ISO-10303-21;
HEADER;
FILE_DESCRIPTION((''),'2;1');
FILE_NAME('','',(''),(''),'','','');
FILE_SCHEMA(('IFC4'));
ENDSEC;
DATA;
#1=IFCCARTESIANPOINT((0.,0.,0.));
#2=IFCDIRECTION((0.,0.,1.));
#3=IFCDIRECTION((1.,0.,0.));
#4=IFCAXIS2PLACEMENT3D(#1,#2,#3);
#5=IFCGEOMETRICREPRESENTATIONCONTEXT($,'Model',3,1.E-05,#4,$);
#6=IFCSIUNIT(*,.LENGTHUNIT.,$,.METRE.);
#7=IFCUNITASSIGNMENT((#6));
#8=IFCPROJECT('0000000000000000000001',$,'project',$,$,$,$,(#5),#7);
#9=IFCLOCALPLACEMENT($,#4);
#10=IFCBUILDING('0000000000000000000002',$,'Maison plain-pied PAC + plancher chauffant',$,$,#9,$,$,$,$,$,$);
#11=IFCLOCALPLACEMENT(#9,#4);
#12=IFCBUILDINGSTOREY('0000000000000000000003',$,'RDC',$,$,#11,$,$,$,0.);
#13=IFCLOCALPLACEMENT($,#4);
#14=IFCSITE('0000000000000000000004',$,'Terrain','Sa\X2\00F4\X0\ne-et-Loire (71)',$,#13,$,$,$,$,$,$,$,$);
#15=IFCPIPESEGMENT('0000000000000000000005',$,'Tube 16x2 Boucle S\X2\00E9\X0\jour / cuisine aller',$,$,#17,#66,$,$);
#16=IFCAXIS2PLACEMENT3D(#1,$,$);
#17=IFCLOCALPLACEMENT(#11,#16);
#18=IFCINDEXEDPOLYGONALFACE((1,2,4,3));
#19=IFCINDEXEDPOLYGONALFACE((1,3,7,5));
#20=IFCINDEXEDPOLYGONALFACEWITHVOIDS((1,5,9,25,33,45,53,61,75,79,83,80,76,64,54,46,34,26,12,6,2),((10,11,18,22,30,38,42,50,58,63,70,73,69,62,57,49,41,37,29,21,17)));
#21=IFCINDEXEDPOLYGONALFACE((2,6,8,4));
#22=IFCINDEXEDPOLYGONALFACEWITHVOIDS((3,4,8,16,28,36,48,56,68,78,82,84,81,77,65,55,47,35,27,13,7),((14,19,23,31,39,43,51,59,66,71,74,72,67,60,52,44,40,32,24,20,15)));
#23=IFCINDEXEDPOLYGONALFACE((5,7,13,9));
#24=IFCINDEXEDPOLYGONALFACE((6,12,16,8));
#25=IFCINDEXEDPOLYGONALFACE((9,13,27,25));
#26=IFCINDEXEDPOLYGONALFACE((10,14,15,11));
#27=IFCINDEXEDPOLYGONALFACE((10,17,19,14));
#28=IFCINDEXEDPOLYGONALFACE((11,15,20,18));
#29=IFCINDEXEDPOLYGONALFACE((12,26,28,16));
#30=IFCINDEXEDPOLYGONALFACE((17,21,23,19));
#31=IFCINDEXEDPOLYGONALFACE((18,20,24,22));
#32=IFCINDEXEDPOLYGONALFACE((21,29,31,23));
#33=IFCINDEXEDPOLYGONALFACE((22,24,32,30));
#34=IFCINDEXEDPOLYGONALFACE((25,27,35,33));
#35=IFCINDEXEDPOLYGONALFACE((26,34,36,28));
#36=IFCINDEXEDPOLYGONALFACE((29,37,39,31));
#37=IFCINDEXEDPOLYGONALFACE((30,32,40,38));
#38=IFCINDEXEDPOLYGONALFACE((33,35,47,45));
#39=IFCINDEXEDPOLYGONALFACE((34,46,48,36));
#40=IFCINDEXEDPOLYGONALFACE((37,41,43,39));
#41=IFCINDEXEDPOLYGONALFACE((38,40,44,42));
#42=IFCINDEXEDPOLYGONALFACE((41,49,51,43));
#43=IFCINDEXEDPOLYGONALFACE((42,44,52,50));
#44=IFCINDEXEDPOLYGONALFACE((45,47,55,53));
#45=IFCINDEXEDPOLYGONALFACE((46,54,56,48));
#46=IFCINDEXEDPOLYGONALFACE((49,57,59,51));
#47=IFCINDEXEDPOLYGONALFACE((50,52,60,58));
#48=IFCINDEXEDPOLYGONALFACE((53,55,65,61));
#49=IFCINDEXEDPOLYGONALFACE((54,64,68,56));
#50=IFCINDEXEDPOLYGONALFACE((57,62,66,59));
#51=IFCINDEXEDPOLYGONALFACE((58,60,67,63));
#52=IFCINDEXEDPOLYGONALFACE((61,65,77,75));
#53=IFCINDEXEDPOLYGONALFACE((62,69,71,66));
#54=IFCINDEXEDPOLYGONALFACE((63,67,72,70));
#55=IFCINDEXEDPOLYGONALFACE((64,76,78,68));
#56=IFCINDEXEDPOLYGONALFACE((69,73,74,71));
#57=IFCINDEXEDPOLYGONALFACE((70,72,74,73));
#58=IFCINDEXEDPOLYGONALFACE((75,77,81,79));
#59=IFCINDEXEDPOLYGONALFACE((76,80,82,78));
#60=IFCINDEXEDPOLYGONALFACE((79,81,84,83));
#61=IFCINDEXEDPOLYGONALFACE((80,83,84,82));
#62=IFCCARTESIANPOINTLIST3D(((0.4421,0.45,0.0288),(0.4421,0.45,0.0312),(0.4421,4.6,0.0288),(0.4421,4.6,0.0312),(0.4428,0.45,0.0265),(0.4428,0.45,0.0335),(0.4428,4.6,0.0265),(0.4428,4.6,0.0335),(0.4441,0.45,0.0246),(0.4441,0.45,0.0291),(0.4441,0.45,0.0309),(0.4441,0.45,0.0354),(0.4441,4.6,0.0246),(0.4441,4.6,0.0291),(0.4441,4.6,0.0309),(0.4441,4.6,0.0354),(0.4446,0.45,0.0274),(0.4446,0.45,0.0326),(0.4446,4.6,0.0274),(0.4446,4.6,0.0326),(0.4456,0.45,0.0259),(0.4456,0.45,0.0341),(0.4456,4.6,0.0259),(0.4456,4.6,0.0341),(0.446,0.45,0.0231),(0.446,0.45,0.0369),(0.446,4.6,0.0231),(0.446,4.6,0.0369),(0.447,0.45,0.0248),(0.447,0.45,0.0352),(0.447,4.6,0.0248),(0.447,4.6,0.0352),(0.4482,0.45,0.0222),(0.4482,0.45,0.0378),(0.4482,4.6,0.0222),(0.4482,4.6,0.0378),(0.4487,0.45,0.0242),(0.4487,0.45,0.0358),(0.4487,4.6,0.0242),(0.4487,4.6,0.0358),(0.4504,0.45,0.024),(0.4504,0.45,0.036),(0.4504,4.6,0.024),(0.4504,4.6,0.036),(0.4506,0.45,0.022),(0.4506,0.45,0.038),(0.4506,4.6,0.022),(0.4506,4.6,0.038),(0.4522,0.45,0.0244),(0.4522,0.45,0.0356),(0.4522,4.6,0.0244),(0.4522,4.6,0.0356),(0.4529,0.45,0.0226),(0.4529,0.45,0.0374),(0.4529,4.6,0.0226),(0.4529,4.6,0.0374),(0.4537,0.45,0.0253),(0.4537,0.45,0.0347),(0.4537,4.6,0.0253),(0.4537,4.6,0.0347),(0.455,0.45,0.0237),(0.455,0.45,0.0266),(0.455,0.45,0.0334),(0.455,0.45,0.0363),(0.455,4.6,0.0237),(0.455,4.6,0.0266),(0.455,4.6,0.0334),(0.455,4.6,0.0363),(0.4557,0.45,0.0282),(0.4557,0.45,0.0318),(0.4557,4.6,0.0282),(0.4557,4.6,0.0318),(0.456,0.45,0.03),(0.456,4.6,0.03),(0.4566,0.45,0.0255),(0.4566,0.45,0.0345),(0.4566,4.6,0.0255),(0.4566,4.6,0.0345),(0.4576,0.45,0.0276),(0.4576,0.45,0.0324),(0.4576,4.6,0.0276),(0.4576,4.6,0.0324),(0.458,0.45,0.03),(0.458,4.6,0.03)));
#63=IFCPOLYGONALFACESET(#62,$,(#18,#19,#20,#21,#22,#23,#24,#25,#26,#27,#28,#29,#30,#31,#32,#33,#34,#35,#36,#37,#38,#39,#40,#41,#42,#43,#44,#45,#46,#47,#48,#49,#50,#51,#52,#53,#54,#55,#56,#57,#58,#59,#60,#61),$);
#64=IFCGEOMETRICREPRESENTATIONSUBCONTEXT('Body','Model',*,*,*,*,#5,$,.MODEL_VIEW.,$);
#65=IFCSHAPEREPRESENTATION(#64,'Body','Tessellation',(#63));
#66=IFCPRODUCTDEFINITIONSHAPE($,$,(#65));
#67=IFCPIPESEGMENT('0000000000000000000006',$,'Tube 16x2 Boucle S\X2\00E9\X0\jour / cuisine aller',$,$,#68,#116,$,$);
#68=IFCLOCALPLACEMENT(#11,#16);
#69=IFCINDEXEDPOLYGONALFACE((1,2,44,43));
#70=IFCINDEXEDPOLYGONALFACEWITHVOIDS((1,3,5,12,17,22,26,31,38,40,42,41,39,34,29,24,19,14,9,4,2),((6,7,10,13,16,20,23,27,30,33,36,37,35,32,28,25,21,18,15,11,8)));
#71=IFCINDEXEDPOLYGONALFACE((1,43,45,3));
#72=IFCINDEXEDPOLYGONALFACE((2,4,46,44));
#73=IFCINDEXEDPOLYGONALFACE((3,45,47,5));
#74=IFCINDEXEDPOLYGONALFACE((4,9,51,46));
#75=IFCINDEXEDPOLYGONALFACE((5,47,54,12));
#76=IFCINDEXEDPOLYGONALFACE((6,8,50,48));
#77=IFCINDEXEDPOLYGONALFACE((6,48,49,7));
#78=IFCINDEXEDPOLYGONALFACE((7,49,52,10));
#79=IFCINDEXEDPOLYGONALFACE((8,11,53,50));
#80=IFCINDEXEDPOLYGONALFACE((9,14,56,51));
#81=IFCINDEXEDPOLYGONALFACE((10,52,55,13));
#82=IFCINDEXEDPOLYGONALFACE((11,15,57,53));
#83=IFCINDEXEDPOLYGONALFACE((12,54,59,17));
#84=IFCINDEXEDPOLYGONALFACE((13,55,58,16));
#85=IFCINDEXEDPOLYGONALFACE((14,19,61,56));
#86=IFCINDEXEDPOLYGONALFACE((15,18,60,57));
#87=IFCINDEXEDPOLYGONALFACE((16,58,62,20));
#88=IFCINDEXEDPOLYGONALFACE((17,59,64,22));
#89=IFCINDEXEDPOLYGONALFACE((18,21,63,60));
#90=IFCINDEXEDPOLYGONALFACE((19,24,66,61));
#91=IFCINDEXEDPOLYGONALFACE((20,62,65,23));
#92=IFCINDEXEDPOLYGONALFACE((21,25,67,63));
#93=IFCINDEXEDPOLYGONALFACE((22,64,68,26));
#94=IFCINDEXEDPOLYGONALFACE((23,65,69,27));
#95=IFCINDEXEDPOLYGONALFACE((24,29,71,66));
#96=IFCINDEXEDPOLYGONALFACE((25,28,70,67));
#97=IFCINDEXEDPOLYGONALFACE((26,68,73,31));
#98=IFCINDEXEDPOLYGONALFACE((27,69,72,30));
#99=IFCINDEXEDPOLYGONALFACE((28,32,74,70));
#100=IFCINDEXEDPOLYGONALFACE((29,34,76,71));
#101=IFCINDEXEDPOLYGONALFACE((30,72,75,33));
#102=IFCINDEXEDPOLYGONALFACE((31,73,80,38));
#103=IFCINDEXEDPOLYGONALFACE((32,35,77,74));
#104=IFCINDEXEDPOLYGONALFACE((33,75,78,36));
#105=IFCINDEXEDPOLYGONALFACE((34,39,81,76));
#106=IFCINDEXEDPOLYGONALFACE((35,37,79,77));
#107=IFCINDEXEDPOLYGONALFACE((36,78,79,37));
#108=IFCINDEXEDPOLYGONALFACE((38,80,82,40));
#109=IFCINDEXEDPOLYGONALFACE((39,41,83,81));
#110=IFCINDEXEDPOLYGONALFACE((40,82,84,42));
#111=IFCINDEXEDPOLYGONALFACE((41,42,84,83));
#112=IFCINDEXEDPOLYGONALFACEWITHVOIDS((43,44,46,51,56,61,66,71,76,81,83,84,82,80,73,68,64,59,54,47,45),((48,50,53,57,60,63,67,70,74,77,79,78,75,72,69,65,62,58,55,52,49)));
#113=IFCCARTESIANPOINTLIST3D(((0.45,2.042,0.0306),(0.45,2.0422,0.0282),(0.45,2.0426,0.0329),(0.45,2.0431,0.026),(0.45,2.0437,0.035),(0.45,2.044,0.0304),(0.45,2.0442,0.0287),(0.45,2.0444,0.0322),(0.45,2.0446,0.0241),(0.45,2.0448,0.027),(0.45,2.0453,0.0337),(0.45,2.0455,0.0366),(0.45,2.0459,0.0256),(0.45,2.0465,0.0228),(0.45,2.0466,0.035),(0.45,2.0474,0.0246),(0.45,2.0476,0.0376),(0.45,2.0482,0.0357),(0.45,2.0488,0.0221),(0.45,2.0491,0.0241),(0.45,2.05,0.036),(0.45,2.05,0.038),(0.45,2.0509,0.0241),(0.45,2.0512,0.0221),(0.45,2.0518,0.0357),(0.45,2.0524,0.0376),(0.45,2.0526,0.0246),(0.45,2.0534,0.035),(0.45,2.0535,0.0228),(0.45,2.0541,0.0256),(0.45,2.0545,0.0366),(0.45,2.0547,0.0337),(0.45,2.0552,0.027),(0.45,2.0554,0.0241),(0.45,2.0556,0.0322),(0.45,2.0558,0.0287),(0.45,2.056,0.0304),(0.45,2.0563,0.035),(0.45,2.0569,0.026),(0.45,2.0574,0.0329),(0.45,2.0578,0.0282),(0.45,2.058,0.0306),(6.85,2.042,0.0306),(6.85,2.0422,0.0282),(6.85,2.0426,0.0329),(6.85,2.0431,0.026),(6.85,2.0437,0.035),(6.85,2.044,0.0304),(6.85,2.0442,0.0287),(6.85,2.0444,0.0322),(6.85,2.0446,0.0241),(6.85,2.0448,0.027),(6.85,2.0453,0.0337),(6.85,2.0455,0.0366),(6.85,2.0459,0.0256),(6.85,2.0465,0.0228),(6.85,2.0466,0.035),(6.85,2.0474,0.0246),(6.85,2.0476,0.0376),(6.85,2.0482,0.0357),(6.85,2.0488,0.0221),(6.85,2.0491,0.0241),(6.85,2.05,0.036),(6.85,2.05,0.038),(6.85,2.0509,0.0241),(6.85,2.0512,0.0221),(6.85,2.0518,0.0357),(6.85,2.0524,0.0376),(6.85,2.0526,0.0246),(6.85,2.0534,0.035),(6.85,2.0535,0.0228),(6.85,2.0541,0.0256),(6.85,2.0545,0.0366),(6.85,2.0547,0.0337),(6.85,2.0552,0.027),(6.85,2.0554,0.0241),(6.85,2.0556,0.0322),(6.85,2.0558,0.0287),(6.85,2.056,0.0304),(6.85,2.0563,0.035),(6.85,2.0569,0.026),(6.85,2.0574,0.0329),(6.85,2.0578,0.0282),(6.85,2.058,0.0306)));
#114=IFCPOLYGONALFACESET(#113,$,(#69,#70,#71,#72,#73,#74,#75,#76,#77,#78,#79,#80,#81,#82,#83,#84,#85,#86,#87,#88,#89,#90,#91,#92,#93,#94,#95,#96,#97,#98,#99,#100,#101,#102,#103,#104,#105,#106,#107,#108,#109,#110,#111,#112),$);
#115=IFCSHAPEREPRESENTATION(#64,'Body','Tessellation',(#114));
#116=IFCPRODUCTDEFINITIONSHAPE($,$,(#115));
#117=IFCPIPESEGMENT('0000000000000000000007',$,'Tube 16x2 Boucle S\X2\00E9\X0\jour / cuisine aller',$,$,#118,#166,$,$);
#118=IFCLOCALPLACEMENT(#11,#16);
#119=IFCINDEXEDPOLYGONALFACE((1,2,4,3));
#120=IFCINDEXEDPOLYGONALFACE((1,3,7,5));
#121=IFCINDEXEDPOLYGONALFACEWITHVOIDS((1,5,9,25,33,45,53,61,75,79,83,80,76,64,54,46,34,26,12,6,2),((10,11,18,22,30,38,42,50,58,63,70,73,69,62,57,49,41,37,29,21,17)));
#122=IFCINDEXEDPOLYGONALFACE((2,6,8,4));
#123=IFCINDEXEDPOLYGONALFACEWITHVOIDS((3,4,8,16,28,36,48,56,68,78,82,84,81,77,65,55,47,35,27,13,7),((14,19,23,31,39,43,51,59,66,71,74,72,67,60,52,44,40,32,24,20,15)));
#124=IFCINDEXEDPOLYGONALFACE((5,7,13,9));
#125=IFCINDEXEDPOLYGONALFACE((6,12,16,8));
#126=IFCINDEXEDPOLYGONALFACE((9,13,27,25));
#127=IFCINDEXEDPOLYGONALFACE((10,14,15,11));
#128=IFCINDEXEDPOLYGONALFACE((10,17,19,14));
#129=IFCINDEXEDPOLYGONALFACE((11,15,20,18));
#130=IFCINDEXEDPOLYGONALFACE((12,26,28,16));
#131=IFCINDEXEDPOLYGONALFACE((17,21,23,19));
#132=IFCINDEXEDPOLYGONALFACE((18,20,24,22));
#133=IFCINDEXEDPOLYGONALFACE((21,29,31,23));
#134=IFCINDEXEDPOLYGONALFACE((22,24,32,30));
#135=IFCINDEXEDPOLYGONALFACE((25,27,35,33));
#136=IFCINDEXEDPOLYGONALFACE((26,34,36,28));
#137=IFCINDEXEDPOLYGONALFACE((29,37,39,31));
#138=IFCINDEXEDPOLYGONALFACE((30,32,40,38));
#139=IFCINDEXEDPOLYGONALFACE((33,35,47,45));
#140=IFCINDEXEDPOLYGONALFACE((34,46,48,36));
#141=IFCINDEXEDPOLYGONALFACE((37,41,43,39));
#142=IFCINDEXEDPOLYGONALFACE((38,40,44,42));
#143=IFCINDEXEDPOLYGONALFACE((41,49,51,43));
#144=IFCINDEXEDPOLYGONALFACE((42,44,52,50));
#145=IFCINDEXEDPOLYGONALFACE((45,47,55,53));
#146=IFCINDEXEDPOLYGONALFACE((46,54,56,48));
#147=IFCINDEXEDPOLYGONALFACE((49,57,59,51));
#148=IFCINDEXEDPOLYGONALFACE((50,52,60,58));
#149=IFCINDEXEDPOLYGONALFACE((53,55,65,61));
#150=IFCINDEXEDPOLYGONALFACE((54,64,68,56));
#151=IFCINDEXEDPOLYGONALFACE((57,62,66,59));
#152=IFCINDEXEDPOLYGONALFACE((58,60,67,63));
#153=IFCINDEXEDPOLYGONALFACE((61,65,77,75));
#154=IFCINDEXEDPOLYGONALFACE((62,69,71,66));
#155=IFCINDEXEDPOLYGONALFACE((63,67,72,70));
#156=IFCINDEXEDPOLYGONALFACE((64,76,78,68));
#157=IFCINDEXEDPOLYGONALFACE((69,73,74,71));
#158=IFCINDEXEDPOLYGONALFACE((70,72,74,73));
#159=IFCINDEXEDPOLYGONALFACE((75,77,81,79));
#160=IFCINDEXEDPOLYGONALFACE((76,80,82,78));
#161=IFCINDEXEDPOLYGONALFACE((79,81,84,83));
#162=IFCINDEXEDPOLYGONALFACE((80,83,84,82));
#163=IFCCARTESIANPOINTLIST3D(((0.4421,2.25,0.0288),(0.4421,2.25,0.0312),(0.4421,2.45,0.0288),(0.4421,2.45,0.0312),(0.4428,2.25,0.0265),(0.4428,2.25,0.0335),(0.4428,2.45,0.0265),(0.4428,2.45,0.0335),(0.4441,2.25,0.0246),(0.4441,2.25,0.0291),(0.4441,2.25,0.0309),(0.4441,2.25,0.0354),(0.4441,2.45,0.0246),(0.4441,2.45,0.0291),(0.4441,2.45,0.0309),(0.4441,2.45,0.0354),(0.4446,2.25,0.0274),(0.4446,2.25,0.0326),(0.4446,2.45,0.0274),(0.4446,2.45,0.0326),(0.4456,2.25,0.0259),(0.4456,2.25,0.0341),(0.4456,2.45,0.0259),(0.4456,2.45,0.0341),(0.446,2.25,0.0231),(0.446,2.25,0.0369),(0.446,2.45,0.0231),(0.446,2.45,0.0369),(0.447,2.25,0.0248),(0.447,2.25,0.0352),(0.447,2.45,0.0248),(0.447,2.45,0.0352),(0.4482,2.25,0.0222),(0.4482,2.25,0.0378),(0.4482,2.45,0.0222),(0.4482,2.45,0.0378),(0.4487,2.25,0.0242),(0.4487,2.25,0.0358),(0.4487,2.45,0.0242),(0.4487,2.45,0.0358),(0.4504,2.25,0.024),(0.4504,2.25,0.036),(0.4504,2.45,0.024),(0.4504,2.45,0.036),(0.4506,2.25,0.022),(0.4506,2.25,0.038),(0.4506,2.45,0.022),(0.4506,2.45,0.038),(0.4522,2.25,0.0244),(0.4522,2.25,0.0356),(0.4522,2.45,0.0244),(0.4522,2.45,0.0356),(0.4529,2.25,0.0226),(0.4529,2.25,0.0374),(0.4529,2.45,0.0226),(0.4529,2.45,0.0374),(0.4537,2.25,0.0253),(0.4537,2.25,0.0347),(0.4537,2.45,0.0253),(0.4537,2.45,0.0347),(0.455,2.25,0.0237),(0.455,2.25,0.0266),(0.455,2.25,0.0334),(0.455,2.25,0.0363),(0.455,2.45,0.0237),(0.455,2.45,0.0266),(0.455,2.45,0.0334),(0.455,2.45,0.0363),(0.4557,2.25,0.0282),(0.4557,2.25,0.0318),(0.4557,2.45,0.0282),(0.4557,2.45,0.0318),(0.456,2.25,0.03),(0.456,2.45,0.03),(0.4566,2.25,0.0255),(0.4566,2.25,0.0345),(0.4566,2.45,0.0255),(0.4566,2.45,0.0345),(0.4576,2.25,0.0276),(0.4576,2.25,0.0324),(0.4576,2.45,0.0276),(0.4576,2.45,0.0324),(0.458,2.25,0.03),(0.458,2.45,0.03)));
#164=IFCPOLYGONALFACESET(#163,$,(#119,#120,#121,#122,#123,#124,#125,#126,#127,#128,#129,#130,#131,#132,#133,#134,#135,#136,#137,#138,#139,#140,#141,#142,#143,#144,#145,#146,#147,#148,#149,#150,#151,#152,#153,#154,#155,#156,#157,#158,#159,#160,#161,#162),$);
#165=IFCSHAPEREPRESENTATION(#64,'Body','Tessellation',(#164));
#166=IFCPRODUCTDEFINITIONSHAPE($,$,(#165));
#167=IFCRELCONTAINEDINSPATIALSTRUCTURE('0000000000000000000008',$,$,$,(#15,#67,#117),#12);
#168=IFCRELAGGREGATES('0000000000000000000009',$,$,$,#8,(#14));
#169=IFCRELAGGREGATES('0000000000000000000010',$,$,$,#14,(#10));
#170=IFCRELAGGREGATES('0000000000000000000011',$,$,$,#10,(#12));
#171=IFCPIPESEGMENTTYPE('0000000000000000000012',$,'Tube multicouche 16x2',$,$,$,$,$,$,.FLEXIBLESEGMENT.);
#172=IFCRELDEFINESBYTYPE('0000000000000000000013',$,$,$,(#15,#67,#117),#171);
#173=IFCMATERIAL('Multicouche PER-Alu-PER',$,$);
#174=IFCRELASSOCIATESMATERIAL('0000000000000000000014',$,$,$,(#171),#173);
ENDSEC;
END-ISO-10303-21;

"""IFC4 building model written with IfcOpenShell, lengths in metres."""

from ifc_helpers import new_model, si_unit, frame, origin_with_axes, place, context, subcontext, project, spatial, hollow_circle, extrude, material, type_object, element, save


model = new_model("IFC4")

# Units and contexts
model_context = context("Model", 3, precision=1e-05, world=origin_with_axes())
body_context = subcontext(model_context, "Body", "Model", "MODEL_VIEW")
ifc_project = project(units=[si_unit("LENGTHUNIT", "METRE")], contexts=[model_context])

# Site, building, storey
site_placement = place(None, origin_with_axes())
site = spatial("IfcSite", under=ifc_project, at=site_placement, Name="Terrain", Description="Saône-et-Loire (71)")
building_placement = place(None, origin_with_axes())
building = spatial("IfcBuilding", under=site, at=building_placement, Name="Maison plain-pied PAC + plancher chauffant")
storey_placement = place(building_placement, origin_with_axes())
storey = spatial("IfcBuildingStorey", under=building, at=storey_placement, Name="RDC", Elevation=0.0)

# Pipe segments
ifc_material = material(Name="Multicouche PER-Alu-PER")
pipe_segment_type = type_object("IfcPipeSegmentType", Name="Tube multicouche 16x2", PredefinedType="FLEXIBLESEGMENT", material=ifc_material)
pipe_segment_1_placement = place(storey_placement, frame((0.45, 4.6, 0.03), z_axis=(0.0, -1.0, 0.0), x_axis=(1.0, 0.0, 0.0)))
element("IfcPipeSegment", 1, at=pipe_segment_1_placement, inside=storey, type_object=pipe_segment_type, Name="Tube 16x2 Boucle Séjour / cuisine aller", context=body_context, shape_type="SweptSolid", body=[
    extrude(hollow_circle(Radius=0.008, WallThickness=0.002), origin_with_axes(), (0.0, 0.0, 1.0), 4.15),
])
pipe_segment_2_placement = place(storey_placement, frame((0.45, 2.05, 0.03), z_axis=(1.0, 0.0, 0.0), x_axis=(0.0, 0.0, 1.0)))
element("IfcPipeSegment", 2, at=pipe_segment_2_placement, inside=storey, type_object=pipe_segment_type, Name="Tube 16x2 Boucle Séjour / cuisine aller", context=body_context, shape_type="SweptSolid", body=[
    extrude(hollow_circle(Radius=0.008, WallThickness=0.002), origin_with_axes(), (0.0, 0.0, 1.0), 6.4),
])
pipe_segment_3_placement = place(storey_placement, frame((0.45, 2.25, 0.03), z_axis=(0.0, 1.0, 0.0), x_axis=(1.0, 0.0, 0.0)))
element("IfcPipeSegment", 3, at=pipe_segment_3_placement, inside=storey, type_object=pipe_segment_type, Name="Tube 16x2 Boucle Séjour / cuisine aller", context=body_context, shape_type="SweptSolid", body=[
    extrude(hollow_circle(Radius=0.008, WallThickness=0.002), origin_with_axes(), (0.0, 0.0, 1.0), 0.2),
])

save(model, "model.ifc")
